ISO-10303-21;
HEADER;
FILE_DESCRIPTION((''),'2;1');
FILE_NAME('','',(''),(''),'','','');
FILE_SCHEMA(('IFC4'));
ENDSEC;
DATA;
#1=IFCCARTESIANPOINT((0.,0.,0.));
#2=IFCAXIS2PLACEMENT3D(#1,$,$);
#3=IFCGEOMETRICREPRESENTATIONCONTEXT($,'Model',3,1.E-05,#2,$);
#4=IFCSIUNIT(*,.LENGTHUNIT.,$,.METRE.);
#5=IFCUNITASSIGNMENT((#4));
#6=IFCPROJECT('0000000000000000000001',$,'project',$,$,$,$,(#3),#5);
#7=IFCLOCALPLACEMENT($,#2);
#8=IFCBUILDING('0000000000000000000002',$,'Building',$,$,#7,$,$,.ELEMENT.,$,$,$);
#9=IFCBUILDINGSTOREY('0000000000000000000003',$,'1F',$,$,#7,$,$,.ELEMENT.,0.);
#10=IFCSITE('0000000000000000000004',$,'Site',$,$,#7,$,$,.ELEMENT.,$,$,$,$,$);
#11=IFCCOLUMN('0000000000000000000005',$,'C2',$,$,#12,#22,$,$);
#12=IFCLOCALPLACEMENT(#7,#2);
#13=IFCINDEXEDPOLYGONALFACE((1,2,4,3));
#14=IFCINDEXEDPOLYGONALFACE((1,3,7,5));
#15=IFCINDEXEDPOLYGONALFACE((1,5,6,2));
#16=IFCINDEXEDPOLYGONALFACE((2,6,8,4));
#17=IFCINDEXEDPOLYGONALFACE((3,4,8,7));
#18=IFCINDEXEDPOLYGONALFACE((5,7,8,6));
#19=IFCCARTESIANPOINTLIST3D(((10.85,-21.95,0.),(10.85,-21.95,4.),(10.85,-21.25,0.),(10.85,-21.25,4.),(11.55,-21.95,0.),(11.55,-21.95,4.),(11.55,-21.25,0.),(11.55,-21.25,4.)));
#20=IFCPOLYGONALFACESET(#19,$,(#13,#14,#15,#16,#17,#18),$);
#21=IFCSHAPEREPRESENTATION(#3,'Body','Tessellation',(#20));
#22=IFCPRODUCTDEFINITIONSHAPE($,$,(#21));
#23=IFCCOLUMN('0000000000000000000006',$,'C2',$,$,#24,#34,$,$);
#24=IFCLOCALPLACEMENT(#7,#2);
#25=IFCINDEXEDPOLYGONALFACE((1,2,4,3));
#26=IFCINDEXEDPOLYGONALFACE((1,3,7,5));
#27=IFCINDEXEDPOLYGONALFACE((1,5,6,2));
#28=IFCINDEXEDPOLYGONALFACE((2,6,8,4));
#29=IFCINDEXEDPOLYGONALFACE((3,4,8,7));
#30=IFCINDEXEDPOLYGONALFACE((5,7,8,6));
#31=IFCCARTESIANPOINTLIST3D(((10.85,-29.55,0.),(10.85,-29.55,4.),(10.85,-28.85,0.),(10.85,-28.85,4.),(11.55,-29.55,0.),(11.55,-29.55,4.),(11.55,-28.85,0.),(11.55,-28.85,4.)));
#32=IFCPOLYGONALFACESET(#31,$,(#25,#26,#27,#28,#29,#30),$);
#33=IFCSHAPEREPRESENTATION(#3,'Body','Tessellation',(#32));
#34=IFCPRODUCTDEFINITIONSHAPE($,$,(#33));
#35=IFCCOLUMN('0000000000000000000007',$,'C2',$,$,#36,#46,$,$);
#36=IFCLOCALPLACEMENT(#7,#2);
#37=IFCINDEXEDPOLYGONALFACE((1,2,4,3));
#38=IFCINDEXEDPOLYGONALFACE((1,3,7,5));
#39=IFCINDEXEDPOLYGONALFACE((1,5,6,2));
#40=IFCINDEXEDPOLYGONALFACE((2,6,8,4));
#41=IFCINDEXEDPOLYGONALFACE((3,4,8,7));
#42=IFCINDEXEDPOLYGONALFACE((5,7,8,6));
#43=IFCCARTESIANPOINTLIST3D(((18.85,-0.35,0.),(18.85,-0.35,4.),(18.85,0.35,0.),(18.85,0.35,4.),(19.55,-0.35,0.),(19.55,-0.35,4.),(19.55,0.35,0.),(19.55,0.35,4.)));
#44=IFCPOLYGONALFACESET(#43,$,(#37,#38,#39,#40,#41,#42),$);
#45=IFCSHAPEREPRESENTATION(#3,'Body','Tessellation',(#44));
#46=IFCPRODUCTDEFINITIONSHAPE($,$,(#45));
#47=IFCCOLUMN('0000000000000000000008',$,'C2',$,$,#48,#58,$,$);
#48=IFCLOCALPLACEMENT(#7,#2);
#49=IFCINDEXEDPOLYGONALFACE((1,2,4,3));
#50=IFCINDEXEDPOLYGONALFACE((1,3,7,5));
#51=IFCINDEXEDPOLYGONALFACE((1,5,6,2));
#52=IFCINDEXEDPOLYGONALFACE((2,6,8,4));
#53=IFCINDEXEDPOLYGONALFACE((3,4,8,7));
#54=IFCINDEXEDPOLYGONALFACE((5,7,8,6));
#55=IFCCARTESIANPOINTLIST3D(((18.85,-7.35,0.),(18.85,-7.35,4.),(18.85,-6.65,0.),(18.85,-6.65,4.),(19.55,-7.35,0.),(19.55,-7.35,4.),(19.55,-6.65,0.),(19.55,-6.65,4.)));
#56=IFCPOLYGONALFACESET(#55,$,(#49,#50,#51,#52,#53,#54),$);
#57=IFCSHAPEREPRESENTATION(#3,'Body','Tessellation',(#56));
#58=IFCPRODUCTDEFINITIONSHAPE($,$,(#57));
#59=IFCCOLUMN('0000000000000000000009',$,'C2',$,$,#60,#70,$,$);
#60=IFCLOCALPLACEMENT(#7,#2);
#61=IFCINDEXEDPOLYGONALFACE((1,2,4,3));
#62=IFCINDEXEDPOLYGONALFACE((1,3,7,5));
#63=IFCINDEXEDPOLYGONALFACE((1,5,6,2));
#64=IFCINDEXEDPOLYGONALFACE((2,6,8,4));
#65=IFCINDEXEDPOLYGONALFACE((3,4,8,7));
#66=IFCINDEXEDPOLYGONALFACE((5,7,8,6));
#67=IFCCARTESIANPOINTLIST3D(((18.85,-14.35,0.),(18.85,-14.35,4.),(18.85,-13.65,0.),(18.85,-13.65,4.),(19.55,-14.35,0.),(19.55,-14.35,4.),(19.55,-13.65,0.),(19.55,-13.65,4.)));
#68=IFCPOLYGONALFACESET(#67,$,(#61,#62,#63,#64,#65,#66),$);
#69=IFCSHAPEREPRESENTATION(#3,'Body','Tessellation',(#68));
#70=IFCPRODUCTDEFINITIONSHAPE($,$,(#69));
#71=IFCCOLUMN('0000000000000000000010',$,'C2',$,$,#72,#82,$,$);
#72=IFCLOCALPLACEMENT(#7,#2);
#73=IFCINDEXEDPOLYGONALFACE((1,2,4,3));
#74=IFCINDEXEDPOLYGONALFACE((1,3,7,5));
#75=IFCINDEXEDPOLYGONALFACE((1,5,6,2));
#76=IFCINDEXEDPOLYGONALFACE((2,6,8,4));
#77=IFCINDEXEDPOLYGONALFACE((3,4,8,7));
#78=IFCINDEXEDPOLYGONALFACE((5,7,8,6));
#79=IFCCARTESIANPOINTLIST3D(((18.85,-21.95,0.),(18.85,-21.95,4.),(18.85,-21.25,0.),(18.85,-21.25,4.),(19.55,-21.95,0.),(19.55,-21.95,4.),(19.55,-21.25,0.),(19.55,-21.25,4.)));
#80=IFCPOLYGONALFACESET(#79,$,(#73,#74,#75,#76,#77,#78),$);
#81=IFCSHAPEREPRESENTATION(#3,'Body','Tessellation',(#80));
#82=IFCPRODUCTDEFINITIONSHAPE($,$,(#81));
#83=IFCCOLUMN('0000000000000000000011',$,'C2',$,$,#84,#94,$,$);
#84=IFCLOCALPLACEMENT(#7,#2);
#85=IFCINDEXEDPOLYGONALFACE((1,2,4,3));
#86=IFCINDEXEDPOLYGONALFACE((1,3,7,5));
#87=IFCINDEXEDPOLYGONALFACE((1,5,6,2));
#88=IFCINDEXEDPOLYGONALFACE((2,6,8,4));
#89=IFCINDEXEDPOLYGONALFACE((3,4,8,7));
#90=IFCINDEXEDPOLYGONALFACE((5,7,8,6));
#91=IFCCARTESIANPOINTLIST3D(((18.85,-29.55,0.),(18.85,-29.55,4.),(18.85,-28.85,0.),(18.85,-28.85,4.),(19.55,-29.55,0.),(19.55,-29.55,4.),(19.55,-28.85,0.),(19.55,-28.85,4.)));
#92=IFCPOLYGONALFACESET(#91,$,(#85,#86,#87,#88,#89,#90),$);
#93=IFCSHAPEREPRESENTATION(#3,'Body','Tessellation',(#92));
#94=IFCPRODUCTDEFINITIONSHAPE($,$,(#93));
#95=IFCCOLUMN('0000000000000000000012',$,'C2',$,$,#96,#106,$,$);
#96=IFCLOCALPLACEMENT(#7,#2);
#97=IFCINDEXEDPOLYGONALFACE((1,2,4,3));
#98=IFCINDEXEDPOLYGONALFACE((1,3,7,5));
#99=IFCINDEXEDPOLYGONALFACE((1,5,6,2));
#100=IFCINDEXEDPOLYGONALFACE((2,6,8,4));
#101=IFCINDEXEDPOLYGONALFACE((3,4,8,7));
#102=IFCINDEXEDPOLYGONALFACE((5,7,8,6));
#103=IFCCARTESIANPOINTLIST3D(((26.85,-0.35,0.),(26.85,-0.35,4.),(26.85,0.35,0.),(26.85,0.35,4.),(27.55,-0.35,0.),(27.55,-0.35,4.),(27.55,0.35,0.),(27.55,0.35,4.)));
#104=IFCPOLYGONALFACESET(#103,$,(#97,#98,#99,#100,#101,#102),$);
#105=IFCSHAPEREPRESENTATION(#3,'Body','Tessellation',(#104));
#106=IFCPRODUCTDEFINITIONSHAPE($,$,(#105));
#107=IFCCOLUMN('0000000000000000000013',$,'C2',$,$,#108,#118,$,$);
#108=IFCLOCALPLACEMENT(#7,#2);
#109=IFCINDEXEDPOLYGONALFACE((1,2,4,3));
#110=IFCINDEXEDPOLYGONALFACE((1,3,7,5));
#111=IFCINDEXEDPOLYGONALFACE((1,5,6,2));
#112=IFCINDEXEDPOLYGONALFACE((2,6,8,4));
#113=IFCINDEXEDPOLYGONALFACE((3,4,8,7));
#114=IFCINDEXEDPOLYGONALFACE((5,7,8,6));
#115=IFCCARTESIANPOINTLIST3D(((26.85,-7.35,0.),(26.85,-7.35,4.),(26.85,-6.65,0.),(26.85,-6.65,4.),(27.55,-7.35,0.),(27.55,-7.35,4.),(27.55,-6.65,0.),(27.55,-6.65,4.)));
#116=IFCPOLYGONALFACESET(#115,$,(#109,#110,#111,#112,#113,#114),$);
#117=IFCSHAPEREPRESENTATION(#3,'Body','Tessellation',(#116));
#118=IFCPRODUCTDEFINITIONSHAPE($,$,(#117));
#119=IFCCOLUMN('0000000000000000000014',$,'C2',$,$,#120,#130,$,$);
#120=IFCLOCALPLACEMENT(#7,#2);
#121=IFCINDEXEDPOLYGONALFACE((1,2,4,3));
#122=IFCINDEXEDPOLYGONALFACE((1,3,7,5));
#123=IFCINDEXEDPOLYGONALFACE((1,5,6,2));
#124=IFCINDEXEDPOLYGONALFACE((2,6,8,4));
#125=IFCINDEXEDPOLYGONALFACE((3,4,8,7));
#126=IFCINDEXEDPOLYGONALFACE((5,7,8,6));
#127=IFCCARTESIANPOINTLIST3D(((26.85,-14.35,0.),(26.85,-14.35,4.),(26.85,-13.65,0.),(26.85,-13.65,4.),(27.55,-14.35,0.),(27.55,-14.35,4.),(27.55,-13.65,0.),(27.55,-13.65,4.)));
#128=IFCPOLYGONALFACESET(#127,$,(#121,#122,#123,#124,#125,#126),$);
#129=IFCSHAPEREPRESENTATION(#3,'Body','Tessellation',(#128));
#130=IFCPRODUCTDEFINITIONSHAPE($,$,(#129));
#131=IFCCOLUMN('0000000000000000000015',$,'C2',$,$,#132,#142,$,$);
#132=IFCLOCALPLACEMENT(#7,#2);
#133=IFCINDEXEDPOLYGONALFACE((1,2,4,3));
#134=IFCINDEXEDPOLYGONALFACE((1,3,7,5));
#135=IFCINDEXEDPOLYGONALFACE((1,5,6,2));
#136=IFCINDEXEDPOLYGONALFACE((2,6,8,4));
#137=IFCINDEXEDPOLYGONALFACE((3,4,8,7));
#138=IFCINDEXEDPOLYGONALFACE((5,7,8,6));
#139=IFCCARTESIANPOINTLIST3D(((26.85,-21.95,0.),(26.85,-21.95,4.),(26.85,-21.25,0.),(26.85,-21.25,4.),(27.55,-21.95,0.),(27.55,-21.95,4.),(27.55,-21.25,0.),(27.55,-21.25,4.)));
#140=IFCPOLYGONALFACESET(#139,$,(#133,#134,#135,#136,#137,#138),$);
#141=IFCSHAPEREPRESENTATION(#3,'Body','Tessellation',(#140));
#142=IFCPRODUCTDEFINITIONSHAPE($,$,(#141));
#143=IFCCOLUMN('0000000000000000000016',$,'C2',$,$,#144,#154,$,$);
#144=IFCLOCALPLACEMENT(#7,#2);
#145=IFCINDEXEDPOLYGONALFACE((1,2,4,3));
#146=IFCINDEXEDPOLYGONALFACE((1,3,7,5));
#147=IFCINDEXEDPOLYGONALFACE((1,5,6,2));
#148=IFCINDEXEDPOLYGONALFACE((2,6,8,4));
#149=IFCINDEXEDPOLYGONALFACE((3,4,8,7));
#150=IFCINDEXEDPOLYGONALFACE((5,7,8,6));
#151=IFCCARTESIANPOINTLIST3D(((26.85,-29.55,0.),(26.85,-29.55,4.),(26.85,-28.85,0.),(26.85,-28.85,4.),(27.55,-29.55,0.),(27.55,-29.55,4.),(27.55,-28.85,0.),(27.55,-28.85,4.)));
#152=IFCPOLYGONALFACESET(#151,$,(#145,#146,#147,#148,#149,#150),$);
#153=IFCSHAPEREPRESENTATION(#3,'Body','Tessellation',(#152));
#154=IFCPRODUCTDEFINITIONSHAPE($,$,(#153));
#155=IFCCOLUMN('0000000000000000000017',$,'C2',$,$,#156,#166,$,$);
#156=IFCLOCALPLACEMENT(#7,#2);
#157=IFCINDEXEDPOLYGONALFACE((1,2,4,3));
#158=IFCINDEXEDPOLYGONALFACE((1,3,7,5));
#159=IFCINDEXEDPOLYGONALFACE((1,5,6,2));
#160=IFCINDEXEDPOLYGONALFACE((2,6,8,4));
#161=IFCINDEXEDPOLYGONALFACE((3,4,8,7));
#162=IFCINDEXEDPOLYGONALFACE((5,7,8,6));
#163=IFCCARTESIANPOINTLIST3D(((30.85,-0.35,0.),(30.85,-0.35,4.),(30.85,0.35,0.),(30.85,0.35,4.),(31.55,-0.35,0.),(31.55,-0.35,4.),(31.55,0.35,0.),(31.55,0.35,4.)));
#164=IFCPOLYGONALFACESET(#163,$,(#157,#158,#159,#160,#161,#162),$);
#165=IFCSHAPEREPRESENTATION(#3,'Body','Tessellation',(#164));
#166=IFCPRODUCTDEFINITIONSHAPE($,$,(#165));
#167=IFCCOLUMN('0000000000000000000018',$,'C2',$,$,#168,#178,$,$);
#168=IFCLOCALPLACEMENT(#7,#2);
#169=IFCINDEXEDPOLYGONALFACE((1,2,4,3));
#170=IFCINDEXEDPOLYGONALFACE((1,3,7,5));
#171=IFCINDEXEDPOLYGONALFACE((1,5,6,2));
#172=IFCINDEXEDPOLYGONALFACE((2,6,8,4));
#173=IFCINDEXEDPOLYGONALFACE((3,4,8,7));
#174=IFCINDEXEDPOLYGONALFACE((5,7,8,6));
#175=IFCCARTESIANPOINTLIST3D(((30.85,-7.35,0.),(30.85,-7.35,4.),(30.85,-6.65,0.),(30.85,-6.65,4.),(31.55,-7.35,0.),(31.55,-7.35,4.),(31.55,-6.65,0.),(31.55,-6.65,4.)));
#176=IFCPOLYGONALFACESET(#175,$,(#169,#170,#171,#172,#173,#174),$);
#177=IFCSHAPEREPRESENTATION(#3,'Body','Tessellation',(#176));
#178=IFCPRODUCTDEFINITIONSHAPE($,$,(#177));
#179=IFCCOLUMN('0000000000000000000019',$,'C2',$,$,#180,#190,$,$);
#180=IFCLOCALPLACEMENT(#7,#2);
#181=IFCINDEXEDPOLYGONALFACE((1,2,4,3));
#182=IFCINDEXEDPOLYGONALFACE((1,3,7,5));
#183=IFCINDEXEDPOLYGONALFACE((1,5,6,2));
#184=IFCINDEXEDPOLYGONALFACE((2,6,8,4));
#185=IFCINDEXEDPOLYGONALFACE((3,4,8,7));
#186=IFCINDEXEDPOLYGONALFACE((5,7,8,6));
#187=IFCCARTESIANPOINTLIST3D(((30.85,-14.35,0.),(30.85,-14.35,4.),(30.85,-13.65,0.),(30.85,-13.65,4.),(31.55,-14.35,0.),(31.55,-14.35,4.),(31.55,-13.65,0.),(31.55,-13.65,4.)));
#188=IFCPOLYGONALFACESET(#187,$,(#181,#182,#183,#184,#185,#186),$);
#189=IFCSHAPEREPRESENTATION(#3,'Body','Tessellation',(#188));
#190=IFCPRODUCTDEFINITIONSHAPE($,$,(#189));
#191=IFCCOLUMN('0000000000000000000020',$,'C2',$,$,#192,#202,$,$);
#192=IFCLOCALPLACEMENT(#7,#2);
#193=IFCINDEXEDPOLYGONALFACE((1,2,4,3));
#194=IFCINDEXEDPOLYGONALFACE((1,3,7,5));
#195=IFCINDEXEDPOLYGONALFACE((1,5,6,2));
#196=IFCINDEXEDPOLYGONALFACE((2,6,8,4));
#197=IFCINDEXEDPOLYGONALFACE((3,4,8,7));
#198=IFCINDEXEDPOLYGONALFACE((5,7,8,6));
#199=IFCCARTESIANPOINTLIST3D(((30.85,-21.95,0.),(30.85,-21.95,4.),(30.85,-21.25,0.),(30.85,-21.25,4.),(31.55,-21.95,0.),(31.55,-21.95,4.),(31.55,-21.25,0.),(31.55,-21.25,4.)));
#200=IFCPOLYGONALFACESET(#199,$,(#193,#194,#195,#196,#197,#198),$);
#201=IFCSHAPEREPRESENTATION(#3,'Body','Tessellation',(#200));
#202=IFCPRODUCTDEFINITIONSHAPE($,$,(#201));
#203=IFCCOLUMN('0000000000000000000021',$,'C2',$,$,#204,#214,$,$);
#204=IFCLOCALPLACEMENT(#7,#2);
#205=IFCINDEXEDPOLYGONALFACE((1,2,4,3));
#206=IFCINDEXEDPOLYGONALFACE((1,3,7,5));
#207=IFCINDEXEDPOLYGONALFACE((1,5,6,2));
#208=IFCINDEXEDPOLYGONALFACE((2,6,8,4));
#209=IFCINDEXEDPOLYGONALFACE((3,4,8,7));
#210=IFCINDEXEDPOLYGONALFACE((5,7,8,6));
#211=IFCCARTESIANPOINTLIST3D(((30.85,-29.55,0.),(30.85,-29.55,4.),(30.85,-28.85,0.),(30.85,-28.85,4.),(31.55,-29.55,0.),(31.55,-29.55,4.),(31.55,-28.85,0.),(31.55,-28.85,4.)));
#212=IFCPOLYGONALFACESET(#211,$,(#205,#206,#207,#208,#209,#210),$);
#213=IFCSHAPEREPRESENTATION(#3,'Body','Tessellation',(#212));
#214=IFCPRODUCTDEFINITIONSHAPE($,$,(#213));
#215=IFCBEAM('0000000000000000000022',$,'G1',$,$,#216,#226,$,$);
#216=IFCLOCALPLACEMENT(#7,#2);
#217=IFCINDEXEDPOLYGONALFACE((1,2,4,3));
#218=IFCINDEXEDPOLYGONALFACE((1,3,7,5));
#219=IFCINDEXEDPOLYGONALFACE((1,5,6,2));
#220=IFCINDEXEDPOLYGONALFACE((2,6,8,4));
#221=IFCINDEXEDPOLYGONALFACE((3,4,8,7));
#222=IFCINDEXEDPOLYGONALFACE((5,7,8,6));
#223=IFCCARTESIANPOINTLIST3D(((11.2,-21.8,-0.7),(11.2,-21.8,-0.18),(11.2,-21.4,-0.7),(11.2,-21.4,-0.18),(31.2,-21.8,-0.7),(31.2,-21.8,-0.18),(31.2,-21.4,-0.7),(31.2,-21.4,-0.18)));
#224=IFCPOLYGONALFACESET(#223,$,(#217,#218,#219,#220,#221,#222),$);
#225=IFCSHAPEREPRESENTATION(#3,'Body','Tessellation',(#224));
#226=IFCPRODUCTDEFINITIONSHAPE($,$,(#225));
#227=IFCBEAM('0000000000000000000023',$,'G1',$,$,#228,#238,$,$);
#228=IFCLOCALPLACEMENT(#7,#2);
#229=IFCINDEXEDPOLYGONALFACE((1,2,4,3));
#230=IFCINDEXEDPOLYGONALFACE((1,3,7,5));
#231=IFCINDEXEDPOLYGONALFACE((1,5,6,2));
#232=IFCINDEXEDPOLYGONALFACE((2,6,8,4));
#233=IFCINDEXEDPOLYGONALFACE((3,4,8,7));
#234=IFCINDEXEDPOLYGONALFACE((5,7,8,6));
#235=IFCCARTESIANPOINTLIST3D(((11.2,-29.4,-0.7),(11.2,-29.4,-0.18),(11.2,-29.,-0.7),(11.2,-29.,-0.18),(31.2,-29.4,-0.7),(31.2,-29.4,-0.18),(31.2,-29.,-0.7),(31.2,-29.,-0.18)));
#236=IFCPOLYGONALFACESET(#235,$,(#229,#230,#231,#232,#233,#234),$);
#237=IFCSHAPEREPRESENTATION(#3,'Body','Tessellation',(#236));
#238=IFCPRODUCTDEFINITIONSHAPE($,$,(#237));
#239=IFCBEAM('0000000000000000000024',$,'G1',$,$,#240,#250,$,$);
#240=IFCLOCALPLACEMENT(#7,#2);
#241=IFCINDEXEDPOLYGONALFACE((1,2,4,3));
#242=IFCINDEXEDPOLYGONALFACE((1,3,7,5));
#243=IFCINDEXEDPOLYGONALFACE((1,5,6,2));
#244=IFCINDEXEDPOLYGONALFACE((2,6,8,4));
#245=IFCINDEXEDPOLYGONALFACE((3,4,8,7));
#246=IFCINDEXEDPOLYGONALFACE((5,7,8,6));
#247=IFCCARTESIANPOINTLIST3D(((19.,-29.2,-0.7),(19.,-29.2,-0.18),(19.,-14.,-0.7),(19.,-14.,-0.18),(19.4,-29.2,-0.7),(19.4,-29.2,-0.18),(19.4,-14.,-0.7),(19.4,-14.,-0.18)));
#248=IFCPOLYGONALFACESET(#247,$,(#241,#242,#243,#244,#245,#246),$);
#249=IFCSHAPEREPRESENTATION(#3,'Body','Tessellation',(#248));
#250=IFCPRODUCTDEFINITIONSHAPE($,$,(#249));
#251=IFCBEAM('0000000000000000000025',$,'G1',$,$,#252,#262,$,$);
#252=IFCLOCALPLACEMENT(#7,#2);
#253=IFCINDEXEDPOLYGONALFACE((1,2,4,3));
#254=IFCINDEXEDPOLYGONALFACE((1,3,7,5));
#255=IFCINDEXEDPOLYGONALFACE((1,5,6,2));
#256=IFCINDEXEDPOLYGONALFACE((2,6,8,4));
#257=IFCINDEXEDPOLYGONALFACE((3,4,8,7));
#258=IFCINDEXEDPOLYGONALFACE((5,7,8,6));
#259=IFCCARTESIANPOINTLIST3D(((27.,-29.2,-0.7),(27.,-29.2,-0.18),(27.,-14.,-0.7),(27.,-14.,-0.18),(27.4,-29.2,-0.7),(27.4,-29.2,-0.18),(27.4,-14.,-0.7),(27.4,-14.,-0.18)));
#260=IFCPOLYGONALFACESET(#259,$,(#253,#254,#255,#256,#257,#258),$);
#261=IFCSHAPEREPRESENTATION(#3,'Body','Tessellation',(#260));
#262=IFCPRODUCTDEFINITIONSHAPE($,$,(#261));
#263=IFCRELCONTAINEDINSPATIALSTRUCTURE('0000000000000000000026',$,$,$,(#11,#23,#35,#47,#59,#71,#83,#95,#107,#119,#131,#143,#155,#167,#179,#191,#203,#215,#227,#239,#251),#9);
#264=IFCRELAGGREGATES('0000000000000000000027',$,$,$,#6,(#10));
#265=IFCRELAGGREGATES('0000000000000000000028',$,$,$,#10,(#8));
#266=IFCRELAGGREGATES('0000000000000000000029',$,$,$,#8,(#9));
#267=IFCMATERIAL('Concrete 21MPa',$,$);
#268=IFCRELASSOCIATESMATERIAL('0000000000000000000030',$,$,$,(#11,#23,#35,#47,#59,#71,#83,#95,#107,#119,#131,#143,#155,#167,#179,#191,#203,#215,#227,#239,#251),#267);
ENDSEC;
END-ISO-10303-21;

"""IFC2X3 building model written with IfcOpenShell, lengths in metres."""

from ifc_helpers import new_model, si_unit, frame, origin, origin_2d, place, context, project, spatial, rectangle, extrude, material, element, save


model = new_model("IFC2X3")

# Units and contexts
model_context = context("Model", 3, precision=1e-05, world=origin())
ifc_project = project(units=[si_unit("LENGTHUNIT", "METRE")], contexts=[model_context])

# Site, building, storey
placement = place(None, origin())
site = spatial("IfcSite", under=ifc_project, at=placement, Name="Site", CompositionType="ELEMENT")
building = spatial("IfcBuilding", under=site, at=placement, Name="Building", CompositionType="ELEMENT")
storey = spatial("IfcBuildingStorey", under=building, at=placement, Name="1F", CompositionType="ELEMENT", Elevation=0.0)

# Columns
ifc_material_1 = material(Name="Concrete 21MPa")
for number, where, name in (
    (1, (11.2, -21.6, 0.0), "C2"),
    (2, (11.2, -29.2, 0.0), "C2"),
    (3, (19.2, 0.0, 0.0), "C2"),
    (4, (19.2, -7.0, 0.0), "C2"),
    (5, (19.2, -14.0, 0.0), "C2"),
    (6, (19.2, -21.6, 0.0), "C2"),
    (7, (19.2, -29.2, 0.0), "C2"),
    (8, (27.2, 0.0, 0.0), "C2"),
    (9, (27.2, -7.0, 0.0), "C2"),
    (10, (27.2, -14.0, 0.0), "C2"),
    (11, (27.2, -21.6, 0.0), "C2"),
    (12, (27.2, -29.2, 0.0), "C2"),
    (13, (31.2, 0.0, 0.0), "C2"),
    (14, (31.2, -7.0, 0.0), "C2"),
    (15, (31.2, -14.0, 0.0), "C2"),
    (16, (31.2, -21.6, 0.0), "C2"),
    (17, (31.2, -29.2, 0.0), "C2"),
):
    element("IfcColumn", number, at=place(None, frame(where)), inside=storey, material=ifc_material_1, Name=name, context=model_context, shape_type="SweptSolid", body=[
        extrude(rectangle(XDim=0.7, YDim=0.7, at=origin_2d()), origin(), (0.0, 0.0, 1.0), 4.0),
    ])

# Beams
for number, where, name in (
    (18, (21.2, -21.6, -0.7), "G1"),
    (19, (21.2, -29.2, -0.7), "G1"),
):
    element("IfcBeam", number, at=place(None, frame(where)), inside=storey, material=ifc_material_1, Name=name, context=model_context, shape_type="SweptSolid", body=[
        extrude(rectangle(XDim=20.0, YDim=0.4, at=origin_2d()), origin(), (0.0, 0.0, 1.0), 0.52),
    ])
for number, where, name in (
    (20, (19.2, -21.6, -0.7), "G1"),
    (21, (27.2, -21.6, -0.7), "G1"),
):
    element("IfcBeam", number, at=place(None, frame(where)), inside=storey, material=ifc_material_1, Name=name, context=model_context, shape_type="SweptSolid", body=[
        extrude(rectangle(XDim=0.4, YDim=15.2, at=origin_2d()), origin(), (0.0, 0.0, 1.0), 0.52),
    ])

save(model, "model.ifc")
